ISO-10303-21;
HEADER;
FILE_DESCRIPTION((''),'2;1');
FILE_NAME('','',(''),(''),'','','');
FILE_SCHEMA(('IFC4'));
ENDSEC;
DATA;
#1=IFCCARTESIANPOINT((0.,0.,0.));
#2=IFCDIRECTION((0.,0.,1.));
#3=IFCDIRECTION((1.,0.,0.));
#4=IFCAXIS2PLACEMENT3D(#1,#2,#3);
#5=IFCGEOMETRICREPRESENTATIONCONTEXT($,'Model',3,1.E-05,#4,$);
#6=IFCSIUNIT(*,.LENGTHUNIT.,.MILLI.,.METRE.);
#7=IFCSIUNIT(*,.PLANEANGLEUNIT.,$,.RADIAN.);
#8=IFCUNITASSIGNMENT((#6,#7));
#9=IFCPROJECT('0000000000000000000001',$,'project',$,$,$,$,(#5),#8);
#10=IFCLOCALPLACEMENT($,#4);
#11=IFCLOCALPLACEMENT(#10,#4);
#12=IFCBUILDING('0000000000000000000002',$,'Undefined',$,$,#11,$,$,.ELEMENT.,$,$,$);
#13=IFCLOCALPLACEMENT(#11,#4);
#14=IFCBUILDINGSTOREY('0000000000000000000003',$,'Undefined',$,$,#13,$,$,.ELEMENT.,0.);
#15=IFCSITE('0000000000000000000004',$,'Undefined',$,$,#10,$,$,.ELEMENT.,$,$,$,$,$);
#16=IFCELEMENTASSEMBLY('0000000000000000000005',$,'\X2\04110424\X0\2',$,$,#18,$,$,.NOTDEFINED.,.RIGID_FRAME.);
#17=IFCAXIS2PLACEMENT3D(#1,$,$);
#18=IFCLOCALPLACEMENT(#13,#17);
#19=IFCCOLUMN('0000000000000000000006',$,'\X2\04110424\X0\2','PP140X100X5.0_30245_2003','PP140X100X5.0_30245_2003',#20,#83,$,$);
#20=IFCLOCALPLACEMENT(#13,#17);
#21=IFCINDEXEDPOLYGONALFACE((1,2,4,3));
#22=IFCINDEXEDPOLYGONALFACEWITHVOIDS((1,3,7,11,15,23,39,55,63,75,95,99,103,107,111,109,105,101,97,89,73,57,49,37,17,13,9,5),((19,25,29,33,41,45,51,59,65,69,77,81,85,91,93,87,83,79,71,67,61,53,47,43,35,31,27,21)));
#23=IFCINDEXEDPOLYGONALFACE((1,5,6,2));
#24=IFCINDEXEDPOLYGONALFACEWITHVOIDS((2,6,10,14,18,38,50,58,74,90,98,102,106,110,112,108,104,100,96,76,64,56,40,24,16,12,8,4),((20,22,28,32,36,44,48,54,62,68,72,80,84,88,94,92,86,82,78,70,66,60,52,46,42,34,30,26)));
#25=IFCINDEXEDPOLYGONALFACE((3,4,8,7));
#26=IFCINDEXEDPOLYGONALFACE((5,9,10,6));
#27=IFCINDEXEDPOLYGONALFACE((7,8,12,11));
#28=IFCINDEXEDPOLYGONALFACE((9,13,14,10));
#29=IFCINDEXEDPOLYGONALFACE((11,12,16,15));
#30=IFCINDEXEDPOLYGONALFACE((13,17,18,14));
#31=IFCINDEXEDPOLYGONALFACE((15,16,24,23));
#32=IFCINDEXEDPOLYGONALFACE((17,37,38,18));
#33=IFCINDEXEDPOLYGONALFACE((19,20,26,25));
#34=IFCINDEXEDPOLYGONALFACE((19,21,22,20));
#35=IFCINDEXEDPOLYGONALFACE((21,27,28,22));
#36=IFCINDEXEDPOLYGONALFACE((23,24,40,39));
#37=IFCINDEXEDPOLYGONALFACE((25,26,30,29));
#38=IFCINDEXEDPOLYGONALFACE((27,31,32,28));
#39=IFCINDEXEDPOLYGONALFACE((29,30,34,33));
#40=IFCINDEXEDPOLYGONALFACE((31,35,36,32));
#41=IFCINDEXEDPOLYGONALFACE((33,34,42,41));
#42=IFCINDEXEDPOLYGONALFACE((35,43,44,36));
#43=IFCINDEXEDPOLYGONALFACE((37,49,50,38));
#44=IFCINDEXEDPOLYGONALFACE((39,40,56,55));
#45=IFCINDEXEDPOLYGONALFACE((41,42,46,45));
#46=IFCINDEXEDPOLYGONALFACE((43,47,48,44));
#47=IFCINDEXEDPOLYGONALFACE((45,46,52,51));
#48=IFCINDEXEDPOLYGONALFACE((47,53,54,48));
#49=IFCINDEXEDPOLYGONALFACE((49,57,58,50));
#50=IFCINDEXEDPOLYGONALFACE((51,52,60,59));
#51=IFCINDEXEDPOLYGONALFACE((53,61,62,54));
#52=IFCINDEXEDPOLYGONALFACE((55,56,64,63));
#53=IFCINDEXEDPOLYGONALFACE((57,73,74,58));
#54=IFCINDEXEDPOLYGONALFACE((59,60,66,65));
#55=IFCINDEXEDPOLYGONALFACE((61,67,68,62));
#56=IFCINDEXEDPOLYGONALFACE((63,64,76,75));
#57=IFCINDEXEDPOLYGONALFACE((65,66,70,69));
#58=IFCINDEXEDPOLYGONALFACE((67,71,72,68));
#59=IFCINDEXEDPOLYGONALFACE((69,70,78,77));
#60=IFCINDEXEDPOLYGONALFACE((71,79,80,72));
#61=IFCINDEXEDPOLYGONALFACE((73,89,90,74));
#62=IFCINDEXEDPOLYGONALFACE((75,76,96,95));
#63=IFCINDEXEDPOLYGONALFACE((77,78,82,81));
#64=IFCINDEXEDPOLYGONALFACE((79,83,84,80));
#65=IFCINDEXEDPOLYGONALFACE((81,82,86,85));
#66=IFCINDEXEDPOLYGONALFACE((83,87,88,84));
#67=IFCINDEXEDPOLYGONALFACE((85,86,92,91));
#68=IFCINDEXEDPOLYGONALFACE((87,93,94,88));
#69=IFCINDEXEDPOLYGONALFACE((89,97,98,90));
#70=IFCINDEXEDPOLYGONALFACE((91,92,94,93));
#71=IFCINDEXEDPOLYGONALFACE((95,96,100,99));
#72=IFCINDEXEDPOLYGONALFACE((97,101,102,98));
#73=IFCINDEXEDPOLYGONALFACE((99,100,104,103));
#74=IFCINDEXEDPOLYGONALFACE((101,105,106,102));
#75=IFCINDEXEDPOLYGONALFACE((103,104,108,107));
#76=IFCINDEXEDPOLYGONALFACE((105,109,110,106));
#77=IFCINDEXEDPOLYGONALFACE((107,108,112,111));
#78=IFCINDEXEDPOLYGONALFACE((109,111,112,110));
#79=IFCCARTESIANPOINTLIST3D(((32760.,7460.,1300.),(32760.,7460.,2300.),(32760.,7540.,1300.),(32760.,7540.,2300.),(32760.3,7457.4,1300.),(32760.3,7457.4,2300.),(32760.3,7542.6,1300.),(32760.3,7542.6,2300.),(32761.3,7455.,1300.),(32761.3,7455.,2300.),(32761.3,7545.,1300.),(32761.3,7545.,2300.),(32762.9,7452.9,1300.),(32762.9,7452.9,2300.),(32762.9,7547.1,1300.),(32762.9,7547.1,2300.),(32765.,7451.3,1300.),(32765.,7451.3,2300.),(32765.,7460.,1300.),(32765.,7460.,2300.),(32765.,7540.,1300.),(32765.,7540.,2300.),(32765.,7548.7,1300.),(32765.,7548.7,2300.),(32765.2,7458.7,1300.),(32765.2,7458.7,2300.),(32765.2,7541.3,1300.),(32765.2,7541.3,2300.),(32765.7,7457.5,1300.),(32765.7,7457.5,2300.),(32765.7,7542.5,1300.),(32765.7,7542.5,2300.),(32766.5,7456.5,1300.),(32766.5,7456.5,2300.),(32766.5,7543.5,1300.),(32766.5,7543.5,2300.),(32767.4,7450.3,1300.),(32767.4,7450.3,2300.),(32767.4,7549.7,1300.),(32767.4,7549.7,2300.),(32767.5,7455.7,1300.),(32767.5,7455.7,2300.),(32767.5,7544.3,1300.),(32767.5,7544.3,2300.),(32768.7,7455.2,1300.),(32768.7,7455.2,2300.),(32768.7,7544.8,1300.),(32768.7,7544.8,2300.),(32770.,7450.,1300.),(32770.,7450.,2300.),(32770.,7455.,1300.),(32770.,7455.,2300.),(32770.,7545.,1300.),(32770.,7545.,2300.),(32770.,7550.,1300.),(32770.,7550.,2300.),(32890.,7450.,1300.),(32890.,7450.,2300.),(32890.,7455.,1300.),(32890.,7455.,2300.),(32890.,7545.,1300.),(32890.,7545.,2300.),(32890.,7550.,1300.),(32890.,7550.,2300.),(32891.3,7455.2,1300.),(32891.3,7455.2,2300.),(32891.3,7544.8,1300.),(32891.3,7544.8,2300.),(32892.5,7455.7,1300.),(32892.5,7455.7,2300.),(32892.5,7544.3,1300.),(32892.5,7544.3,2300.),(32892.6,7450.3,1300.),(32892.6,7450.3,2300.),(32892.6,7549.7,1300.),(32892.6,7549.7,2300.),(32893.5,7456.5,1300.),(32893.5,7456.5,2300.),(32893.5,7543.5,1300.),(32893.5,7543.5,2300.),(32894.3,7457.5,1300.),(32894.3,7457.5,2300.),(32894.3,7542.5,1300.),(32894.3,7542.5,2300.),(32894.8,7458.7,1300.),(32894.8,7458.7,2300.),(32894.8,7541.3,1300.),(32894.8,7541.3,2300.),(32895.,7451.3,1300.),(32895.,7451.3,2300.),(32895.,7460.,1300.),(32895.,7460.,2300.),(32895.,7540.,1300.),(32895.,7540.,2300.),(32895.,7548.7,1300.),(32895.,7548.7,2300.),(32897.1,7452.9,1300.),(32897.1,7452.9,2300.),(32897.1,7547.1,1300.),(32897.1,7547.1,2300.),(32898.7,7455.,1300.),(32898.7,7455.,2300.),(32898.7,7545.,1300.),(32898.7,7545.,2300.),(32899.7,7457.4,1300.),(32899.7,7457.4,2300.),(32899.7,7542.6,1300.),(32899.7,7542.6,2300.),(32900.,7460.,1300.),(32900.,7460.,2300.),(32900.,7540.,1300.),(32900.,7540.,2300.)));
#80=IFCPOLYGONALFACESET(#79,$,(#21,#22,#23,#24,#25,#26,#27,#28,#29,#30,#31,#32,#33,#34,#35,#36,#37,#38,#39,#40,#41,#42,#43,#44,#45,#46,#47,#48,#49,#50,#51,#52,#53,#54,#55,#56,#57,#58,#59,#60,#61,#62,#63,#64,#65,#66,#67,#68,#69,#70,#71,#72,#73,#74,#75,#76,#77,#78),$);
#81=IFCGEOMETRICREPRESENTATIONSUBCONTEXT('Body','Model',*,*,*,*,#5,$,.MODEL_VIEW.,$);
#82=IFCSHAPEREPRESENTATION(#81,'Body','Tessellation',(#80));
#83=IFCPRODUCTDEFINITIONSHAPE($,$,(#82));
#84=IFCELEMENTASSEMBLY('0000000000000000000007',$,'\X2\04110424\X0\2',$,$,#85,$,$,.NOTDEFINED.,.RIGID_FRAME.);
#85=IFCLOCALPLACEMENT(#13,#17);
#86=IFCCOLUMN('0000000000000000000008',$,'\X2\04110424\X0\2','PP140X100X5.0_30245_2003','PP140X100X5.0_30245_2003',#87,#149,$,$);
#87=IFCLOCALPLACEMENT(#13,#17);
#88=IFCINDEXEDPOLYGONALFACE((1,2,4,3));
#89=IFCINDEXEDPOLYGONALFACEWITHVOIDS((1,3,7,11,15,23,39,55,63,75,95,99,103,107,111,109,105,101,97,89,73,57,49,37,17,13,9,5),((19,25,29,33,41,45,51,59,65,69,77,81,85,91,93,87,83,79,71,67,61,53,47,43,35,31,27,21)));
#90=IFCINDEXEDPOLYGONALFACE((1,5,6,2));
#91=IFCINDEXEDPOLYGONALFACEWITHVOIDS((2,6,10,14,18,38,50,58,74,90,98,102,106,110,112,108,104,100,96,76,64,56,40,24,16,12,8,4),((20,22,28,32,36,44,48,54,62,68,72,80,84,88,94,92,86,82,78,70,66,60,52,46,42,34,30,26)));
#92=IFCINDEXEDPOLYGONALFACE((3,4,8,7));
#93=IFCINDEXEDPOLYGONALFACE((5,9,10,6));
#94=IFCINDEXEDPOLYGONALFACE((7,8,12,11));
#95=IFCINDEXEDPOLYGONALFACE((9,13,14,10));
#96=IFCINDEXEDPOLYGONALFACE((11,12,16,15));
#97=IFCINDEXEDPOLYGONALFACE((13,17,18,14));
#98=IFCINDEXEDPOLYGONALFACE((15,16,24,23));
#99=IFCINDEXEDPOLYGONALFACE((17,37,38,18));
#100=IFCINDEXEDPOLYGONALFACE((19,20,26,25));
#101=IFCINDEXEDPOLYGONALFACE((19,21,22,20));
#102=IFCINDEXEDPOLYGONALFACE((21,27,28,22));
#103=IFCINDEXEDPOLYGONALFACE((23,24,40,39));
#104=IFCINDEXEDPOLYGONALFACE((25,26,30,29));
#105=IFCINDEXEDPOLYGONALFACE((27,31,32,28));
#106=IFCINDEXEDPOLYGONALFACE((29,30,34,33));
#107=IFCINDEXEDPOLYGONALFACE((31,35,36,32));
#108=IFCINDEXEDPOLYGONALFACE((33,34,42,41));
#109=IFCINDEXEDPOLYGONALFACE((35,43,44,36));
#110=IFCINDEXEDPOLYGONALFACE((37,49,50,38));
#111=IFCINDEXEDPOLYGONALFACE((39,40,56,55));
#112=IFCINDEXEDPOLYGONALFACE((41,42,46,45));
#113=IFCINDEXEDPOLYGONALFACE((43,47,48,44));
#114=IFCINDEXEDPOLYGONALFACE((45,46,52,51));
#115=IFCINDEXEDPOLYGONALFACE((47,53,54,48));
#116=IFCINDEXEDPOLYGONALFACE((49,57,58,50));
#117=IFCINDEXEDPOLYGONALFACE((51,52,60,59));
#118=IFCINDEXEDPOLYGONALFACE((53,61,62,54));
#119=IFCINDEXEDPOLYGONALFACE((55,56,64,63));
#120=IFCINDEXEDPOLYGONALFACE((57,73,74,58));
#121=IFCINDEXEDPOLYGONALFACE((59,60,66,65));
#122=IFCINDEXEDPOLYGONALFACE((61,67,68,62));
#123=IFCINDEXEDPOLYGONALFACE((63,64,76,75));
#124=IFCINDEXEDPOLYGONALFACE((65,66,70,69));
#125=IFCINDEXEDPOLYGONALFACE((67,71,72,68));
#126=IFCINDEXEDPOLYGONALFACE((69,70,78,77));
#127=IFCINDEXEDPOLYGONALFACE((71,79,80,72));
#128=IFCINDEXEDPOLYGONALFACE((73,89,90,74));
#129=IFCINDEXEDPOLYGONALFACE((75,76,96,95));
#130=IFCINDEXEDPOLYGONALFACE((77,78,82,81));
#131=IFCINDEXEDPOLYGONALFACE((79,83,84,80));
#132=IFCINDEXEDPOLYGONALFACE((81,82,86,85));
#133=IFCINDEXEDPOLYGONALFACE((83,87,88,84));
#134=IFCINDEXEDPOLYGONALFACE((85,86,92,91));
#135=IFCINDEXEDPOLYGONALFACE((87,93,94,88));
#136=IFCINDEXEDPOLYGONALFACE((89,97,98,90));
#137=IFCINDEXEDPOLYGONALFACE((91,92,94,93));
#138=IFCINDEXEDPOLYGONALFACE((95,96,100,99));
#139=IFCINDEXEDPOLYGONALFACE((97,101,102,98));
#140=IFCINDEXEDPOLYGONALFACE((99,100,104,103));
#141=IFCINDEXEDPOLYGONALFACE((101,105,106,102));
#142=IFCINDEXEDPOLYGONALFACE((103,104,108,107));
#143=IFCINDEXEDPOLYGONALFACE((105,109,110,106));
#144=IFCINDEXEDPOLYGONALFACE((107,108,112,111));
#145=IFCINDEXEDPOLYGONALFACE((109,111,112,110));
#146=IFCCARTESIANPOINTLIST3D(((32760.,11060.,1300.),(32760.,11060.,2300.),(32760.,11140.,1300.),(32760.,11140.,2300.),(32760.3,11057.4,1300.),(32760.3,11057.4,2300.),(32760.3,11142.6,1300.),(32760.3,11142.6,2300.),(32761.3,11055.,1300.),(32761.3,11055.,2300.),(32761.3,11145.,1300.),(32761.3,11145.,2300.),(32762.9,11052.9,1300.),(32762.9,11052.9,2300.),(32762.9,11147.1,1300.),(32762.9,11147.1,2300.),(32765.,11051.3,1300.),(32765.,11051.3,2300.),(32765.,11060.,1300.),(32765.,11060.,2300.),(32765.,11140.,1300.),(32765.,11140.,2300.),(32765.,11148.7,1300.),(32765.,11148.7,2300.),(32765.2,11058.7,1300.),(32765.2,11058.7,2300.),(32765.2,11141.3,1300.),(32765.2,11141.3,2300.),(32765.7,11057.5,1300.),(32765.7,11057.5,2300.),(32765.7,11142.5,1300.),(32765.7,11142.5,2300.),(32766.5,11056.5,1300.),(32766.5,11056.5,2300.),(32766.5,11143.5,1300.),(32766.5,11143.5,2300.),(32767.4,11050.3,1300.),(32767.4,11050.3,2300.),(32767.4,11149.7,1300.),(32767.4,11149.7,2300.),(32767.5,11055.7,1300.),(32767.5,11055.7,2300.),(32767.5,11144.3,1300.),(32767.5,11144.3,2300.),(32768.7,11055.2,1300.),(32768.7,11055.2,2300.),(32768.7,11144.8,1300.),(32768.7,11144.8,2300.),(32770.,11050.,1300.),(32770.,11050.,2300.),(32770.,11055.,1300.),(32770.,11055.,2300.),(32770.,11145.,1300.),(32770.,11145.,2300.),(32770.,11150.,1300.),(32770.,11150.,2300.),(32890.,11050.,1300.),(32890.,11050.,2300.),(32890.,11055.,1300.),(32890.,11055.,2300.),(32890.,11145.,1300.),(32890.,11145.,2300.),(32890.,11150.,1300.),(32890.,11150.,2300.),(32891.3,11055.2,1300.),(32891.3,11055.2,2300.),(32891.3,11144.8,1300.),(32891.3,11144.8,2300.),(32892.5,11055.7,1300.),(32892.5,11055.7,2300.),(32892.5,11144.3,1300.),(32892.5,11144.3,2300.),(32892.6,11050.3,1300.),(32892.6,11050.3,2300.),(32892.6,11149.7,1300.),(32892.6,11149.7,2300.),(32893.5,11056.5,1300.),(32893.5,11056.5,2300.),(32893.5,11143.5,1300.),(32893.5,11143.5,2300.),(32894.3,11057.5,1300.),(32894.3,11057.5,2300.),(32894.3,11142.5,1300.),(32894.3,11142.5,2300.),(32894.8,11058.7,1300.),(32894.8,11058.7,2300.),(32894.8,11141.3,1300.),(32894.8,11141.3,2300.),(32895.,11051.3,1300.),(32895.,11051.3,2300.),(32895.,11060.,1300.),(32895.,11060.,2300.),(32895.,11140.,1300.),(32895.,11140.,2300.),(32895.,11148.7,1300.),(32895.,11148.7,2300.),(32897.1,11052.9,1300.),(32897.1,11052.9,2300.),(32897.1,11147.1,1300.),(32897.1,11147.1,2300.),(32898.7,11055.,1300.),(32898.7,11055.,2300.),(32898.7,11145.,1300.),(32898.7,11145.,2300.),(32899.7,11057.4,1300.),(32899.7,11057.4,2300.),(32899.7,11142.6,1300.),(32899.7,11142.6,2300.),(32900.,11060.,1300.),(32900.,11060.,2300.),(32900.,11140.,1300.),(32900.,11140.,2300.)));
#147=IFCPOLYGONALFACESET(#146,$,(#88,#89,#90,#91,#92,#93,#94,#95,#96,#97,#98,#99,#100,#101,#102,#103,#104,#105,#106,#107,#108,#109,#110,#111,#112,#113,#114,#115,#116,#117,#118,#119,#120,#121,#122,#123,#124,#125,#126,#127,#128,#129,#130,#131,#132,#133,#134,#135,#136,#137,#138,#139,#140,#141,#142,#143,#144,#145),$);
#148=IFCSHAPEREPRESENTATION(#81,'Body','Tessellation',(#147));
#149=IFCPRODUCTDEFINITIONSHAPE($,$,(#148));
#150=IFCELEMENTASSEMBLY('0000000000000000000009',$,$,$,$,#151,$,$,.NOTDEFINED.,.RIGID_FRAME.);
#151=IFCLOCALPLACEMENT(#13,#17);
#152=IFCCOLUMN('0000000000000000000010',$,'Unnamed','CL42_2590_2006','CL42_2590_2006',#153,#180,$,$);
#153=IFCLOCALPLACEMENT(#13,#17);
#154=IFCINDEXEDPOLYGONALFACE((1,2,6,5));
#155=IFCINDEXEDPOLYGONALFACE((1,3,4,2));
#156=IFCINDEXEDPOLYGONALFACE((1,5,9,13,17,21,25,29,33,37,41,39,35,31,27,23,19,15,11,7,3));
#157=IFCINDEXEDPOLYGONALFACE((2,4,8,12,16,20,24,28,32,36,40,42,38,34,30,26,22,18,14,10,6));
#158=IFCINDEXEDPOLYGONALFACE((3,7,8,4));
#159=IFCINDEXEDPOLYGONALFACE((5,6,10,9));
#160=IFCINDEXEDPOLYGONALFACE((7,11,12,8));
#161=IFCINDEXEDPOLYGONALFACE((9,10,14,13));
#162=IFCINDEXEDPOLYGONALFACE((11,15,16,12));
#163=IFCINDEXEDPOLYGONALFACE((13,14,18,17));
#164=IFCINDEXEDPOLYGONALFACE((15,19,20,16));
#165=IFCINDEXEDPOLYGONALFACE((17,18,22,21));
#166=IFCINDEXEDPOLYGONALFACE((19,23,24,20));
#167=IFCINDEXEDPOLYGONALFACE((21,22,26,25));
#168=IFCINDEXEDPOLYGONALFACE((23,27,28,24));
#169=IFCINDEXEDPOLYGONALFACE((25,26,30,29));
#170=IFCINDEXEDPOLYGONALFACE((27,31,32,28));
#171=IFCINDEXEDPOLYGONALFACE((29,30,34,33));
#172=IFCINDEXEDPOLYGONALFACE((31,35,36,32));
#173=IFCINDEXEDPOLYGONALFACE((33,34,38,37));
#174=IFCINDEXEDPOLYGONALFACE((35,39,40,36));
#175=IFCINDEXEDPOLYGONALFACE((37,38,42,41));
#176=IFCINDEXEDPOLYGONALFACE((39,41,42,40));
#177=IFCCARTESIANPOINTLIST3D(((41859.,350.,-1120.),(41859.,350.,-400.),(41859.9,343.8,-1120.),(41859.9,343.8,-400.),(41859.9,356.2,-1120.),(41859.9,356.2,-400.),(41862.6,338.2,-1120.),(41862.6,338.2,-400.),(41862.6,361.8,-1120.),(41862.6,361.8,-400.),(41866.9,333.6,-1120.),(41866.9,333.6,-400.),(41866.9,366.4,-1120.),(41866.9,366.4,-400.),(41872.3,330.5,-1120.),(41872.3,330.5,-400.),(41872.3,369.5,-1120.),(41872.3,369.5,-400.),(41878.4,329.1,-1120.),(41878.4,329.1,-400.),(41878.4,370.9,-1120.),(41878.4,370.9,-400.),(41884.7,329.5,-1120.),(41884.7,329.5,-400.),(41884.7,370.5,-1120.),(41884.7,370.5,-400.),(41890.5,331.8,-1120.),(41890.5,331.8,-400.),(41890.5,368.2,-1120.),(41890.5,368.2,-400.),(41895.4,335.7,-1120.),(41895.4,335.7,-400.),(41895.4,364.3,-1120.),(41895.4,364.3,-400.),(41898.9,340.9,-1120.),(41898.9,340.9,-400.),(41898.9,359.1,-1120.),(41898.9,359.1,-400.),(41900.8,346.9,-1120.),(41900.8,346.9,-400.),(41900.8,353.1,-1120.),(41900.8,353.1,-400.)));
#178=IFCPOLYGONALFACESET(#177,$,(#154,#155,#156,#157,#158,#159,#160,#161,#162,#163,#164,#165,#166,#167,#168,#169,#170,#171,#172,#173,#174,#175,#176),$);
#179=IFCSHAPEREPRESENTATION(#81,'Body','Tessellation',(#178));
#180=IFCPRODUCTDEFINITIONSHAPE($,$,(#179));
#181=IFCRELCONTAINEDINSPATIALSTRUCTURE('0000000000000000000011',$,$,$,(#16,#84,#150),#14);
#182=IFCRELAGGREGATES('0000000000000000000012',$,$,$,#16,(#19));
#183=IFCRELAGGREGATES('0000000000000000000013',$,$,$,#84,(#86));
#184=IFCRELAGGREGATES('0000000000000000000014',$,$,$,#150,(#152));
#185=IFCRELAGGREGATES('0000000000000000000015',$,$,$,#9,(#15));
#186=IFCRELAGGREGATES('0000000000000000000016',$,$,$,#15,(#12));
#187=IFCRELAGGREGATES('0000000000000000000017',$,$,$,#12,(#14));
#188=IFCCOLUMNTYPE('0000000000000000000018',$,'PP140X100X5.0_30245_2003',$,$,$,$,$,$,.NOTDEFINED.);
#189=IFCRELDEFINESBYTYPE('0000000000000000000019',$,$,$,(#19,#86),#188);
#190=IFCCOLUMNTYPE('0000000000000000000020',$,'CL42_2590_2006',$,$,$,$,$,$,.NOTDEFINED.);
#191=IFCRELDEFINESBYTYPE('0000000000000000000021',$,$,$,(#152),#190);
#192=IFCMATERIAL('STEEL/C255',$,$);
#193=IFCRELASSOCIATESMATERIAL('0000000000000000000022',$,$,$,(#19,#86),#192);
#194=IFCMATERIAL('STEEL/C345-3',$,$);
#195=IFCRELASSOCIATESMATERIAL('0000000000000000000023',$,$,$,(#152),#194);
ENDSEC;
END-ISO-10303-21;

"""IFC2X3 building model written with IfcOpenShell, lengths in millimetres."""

from ifc_helpers import new_model, si_unit, frame, origin_with_axes, origin_2d_with_axis, place, context, subcontext, project, spatial, hollow_rectangle, circle, extrude, material, type_object, element, aggregate, save


model = new_model("IFC2X3")

# Units and contexts
model_context = context("Model", 3, precision=1e-05, world=origin_with_axes())
body_context = subcontext(model_context, "Body", "Model", "MODEL_VIEW")
ifc_project = project(units=[si_unit("LENGTHUNIT", "METRE", prefix="MILLI"), si_unit("PLANEANGLEUNIT", "RADIAN")], contexts=[model_context])

# Site, building, storey
site_placement = place(None, origin_with_axes())
site = spatial("IfcSite", under=ifc_project, at=site_placement, Name="Undefined", CompositionType="ELEMENT")
building_placement = place(site_placement, origin_with_axes())
building = spatial("IfcBuilding", under=site, at=building_placement, Name="Undefined", CompositionType="ELEMENT")
storey_placement = place(building_placement, origin_with_axes())
storey = spatial("IfcBuildingStorey", under=building, at=storey_placement, Name="Undefined", CompositionType="ELEMENT", Elevation=0.0)

# Element assemblies, columns
ifc_material_1 = material(Name="STEEL/C255")
column_type_1 = type_object("IfcColumnType", Name="PP140X100X5.0_30245_2003", PredefinedType="NOTDEFINED")
assembly_1_placement = place(storey_placement, origin_with_axes())
assembly_1 = element("IfcElementAssembly", 1, at=assembly_1_placement, inside=storey, Name="БФ2", AssemblyPlace="NOTDEFINED", PredefinedType="RIGID_FRAME")
column_1_placement = place(assembly_1_placement, frame((32830.0, 7500.0, 1300.0), z_axis=(0.0, 0.0, 1.0), x_axis=(-1.0, 0.0, 0.0)))
column_1 = element("IfcColumn", 2, at=column_1_placement, type_object=column_type_1, material=ifc_material_1, Name="БФ2", Description="PP140X100X5.0_30245_2003", ObjectType="PP140X100X5.0_30245_2003", context=body_context, shape_type="SweptSolid", body=[
    extrude(hollow_rectangle(XDim=100.0, YDim=140.0, WallThickness=5.0, InnerFilletRadius=5.0, OuterFilletRadius=10.0, at=origin_2d_with_axis()), frame((0.0, 0.0, 1000.0), z_axis=(0.0, 0.0, -1.0), x_axis=(0.0, 1.0, 0.0)), (0.0, 0.0, 1.0), 1000.0),
])
aggregate(assembly_1, [column_1])
assembly_2_placement = place(storey_placement, origin_with_axes())
assembly_2 = element("IfcElementAssembly", 3, at=assembly_2_placement, inside=storey, Name="БФ2", AssemblyPlace="NOTDEFINED", PredefinedType="RIGID_FRAME")
column_2_placement = place(assembly_2_placement, frame((32830.0, 11100.0, 1300.0), z_axis=(0.0, 0.0, 1.0), x_axis=(1.0, 0.0, 0.0)))
column_2 = element("IfcColumn", 4, at=column_2_placement, type_object=column_type_1, material=ifc_material_1, Name="БФ2", Description="PP140X100X5.0_30245_2003", ObjectType="PP140X100X5.0_30245_2003", context=body_context, shape_type="SweptSolid", body=[
    extrude(hollow_rectangle(XDim=100.0, YDim=140.0, WallThickness=5.0, InnerFilletRadius=5.0, OuterFilletRadius=10.0, at=origin_2d_with_axis()), frame((0.0, 0.0, 1000.0), z_axis=(0.0, 0.0, -1.0), x_axis=(0.0, 1.0, 0.0)), (0.0, 0.0, 1.0), 1000.0),
])
aggregate(assembly_2, [column_2])
assembly_3_placement = place(storey_placement, origin_with_axes())
assembly_3 = element("IfcElementAssembly", 5, at=assembly_3_placement, inside=storey, AssemblyPlace="NOTDEFINED", PredefinedType="RIGID_FRAME")
ifc_material_2 = material(Name="STEEL/C345-3")
column_type_2 = type_object("IfcColumnType", Name="CL42_2590_2006", PredefinedType="NOTDEFINED")
column_3_placement = place(assembly_3_placement, frame((41880.0, 350.0, -1120.0), z_axis=(0.0, 0.0, 1.0), x_axis=(0.0, 1.0, 0.0)))
column_3 = element("IfcColumn", 6, at=column_3_placement, type_object=column_type_2, material=ifc_material_2, Name="Unnamed", Description="CL42_2590_2006", ObjectType="CL42_2590_2006", context=body_context, shape_type="SweptSolid", body=[
    extrude(circle(Radius=21.0, at=origin_2d_with_axis()), frame((0.0, 0.0, 720.0), z_axis=(0.0, 0.0, -1.0), x_axis=(0.0, 1.0, 0.0)), (0.0, 0.0, 1.0), 720.0),
])
aggregate(assembly_3, [column_3])

save(model, "model.ifc")
